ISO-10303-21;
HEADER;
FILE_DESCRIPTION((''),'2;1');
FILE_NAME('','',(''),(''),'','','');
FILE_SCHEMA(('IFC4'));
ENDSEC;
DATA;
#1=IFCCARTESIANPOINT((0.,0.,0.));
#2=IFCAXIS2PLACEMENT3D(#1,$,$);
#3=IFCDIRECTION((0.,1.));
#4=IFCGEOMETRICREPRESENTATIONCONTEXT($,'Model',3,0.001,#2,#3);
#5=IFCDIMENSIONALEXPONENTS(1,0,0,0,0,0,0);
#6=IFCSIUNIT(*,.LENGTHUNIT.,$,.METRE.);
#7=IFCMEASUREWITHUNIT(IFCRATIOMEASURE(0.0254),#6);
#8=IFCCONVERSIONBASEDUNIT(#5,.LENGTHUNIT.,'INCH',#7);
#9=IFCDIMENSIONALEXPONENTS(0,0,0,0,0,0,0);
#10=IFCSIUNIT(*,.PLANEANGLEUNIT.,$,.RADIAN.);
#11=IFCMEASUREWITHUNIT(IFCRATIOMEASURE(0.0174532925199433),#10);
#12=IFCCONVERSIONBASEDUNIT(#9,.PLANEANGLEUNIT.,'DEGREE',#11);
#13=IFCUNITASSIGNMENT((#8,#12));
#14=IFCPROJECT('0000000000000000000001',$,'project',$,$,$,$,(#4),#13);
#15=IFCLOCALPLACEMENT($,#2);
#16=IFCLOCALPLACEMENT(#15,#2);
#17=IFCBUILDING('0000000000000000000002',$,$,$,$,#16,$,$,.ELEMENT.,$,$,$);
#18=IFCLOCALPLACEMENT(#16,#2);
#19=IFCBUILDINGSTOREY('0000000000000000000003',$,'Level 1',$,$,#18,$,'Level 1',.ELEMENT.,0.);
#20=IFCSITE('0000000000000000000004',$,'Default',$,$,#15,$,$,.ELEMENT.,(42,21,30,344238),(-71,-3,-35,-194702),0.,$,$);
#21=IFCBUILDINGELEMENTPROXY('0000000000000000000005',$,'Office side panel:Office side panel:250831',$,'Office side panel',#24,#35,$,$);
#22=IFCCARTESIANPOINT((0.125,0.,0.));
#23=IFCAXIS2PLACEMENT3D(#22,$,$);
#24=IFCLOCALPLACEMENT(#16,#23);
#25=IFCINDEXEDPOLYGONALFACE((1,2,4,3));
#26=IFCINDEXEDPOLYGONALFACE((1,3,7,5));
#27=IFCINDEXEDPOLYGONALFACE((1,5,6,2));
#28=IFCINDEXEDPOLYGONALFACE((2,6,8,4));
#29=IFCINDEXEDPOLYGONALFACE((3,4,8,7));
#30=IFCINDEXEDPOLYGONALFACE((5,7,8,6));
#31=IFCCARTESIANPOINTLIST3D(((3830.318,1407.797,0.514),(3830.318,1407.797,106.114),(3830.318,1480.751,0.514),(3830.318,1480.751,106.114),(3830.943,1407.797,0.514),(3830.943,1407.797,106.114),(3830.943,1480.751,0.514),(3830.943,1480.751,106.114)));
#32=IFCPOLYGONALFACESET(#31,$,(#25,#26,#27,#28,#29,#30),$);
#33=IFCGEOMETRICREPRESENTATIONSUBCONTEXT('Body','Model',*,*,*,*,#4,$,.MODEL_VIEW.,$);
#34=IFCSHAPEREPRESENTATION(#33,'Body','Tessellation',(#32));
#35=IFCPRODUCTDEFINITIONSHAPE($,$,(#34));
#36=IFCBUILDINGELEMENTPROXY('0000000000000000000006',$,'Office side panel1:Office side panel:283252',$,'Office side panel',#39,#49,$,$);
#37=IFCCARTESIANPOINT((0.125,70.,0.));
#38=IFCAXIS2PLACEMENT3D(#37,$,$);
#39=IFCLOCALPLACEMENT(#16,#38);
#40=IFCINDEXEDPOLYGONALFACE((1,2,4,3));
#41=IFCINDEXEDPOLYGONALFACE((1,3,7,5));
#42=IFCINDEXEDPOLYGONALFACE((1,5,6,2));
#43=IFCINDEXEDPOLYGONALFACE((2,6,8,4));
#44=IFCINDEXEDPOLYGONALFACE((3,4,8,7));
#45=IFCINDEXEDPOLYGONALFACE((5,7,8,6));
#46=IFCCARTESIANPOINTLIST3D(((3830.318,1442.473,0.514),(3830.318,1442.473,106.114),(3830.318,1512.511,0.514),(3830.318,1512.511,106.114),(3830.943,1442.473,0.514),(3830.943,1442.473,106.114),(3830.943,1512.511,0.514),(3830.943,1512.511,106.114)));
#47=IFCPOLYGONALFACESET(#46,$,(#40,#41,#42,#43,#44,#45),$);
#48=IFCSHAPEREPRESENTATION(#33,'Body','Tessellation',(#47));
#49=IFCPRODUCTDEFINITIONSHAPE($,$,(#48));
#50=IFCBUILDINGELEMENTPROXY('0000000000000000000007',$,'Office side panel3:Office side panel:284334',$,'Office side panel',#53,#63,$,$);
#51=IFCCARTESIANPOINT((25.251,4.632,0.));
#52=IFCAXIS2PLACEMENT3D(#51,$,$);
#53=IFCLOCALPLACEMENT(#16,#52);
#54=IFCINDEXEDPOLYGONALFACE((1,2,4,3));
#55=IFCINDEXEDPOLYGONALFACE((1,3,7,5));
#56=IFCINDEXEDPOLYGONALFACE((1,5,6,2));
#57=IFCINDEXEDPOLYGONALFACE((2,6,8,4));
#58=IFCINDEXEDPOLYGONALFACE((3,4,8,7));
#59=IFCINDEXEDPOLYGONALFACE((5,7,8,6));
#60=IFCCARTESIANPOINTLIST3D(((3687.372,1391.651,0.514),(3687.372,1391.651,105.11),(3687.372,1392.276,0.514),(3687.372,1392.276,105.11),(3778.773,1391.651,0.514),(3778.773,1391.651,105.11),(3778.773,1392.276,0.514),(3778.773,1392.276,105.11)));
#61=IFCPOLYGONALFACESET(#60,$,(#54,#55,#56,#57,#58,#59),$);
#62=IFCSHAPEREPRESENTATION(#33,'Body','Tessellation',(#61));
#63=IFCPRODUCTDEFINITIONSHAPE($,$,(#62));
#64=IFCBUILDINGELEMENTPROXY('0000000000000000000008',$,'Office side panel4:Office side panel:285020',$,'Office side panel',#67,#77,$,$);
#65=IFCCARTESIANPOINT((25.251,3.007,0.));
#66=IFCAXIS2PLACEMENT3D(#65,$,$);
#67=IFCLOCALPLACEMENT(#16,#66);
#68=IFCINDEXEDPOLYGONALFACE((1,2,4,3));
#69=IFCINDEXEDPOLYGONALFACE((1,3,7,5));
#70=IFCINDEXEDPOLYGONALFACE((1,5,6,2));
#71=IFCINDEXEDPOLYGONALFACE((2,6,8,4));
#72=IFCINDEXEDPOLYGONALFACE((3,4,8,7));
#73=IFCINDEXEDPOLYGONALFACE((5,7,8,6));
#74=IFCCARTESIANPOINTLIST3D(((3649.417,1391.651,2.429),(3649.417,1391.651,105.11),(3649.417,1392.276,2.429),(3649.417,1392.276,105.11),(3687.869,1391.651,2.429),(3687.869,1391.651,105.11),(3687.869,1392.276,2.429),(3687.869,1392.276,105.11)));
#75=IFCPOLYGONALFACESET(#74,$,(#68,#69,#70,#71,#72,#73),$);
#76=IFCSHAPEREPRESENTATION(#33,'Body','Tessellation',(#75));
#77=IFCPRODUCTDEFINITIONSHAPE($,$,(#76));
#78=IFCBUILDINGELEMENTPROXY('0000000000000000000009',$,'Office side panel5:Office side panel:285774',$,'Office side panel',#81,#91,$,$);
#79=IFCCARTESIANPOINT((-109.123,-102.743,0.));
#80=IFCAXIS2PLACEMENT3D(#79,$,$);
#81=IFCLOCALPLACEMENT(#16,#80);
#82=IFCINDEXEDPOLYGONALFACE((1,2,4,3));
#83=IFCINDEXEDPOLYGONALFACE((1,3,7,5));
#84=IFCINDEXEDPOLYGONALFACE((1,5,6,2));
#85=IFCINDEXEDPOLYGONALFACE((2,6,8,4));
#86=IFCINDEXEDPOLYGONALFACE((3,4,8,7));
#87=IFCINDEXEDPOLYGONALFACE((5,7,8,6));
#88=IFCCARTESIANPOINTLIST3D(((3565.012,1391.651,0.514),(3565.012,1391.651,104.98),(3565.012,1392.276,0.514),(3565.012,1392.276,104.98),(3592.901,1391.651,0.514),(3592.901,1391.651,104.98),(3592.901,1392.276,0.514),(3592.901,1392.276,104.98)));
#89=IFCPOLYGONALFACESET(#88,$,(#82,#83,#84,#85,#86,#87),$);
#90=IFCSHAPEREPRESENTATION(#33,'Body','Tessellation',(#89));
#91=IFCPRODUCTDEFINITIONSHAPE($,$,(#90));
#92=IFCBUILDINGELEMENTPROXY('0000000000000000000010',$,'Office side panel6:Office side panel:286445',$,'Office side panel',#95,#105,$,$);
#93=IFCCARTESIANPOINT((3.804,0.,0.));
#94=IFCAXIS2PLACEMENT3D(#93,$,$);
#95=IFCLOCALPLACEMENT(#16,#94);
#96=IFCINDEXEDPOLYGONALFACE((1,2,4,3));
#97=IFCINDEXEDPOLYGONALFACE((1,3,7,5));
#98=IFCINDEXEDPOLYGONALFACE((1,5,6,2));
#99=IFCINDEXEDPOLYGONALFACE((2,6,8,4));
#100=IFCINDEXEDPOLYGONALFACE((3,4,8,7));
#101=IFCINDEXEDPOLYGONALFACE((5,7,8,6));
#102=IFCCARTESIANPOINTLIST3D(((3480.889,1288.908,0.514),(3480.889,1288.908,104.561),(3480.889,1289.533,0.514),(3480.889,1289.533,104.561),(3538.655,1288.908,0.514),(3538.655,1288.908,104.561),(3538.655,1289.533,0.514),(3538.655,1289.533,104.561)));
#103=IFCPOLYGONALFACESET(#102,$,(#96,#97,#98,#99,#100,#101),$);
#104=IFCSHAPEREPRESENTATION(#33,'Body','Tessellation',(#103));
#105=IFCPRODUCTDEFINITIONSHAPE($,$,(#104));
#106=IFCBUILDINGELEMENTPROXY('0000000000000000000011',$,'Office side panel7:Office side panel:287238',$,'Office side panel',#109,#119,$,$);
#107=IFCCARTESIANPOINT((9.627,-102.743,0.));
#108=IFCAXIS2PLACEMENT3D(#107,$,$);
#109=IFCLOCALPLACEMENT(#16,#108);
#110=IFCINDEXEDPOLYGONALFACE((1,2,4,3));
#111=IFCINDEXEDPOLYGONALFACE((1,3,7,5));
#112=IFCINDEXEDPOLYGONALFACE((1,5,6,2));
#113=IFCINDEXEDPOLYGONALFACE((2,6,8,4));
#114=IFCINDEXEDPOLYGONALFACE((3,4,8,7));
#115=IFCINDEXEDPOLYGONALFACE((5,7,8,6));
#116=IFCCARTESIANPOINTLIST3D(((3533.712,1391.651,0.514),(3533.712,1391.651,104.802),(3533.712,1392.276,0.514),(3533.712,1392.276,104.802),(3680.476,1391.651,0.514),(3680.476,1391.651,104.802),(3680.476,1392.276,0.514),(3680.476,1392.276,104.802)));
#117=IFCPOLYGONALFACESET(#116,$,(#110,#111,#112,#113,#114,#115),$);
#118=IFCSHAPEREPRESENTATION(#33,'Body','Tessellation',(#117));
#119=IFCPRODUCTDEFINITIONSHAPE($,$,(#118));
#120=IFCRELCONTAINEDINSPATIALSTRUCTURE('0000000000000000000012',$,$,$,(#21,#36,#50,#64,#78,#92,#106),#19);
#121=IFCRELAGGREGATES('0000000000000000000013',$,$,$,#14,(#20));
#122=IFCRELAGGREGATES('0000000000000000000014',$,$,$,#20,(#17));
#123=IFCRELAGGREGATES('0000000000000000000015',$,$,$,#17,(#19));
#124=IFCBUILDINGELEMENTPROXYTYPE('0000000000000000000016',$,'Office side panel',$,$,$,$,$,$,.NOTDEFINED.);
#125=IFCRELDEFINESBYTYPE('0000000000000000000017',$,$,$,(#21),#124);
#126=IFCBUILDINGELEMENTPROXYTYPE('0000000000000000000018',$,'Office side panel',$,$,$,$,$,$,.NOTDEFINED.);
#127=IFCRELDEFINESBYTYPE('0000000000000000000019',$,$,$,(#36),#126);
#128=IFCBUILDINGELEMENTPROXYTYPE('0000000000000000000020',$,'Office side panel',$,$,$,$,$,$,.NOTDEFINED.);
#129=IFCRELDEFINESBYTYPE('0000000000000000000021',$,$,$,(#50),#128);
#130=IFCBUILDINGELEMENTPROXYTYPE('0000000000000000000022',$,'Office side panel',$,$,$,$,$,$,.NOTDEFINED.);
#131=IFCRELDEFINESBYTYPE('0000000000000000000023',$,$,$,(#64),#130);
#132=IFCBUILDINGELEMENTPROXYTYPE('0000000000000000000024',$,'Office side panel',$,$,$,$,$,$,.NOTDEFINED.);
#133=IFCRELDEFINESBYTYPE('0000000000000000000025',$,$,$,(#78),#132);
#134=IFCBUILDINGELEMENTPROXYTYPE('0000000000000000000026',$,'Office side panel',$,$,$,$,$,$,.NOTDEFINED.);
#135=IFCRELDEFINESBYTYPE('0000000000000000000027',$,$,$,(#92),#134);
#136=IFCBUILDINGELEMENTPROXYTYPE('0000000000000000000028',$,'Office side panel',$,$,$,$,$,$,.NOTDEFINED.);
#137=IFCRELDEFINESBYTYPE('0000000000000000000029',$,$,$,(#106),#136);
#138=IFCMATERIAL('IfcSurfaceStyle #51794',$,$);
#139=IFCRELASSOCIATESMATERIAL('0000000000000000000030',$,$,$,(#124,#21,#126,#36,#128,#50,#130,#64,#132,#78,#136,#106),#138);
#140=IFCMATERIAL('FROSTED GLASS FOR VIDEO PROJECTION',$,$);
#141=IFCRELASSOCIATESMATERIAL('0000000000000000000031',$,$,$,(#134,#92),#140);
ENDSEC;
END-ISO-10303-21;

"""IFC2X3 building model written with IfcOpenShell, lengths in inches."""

from ifc_helpers import new_model, entity, si_unit, converted_unit, direction, frame, frame_2d, origin, origin_2d_with_axis, place, context, subcontext, project, spatial, rectangle, extrude, source, transform, mapped, material, type_object, type_shapes, element, save


model = new_model("IFC2X3")

# Units and contexts
model_context = context("Model", 3, precision=0.001, world=origin(), true_north=direction((0.0, 1.0)))
body_context = subcontext(model_context, "Body", "Model", "MODEL_VIEW")
ifc_project = project(units=[converted_unit("LENGTHUNIT", "INCH", entity("IfcRatioMeasure", 0.0254), si_unit("LENGTHUNIT", "METRE"), dimensions=[1, 0, 0, 0, 0, 0, 0]), converted_unit("PLANEANGLEUNIT", "DEGREE", entity("IfcRatioMeasure", 0.0174532925199433), si_unit("PLANEANGLEUNIT", "RADIAN"), dimensions=[0, 0, 0, 0, 0, 0, 0])], contexts=[model_context])

# Site, building, storey
site_placement = place(None, origin())
site = spatial("IfcSite", under=ifc_project, at=site_placement, Name="Default", CompositionType="ELEMENT", RefLatitude=(42, 21, 30, 344238), RefLongitude=(-71, -3, -35, -194702), RefElevation=0.0)
building_placement = place(site_placement, origin())
building = spatial("IfcBuilding", under=site, at=building_placement, CompositionType="ELEMENT")
storey_placement = place(building_placement, origin())
storey = spatial("IfcBuildingStorey", under=building, at=storey_placement, Name="Level 1", LongName="Level 1", CompositionType="ELEMENT", Elevation=0.0)

# Building element proxies
ifc_material_1 = material(Name="IfcSurfaceStyle #51794")
building_element_proxy_type_1 = type_object("IfcBuildingElementProxyType", Name="Office side panel", PredefinedType="NOTDEFINED", material=ifc_material_1)
shared_shape_1 = source(origin(), body_context, "Body", "SweptSolid", [
    extrude(rectangle(XDim=0.625, YDim=72.954, at=frame_2d((0.0, 0.0), x_axis=(1.0, 0.0))), frame((3830.631, 1444.274, 0.514)), (0.0, 0.0, 1.0), 105.6),
])
type_shapes(building_element_proxy_type_1, [shared_shape_1])
proxy_1_placement = place(building_placement, frame((0.125, 0.0, 0.0)))
element("IfcBuildingElementProxy", 1, at=proxy_1_placement, inside=storey, type_object=building_element_proxy_type_1, material=ifc_material_1, Name="Office side panel:Office side panel:250831", ObjectType="Office side panel", context=body_context, shape_type="MappedRepresentation", body=[
    mapped(shared_shape_1, transform((0.0, 0.0, 0.0), scale=1.0)),
])
building_element_proxy_type_2 = type_object("IfcBuildingElementProxyType", Name="Office side panel", PredefinedType="NOTDEFINED", material=ifc_material_1)
shared_shape_2 = source(origin(), body_context, "Body", "SweptSolid", [
    extrude(rectangle(XDim=0.625, YDim=70.038, at=frame_2d((0.0, 0.0), x_axis=(1.0, 0.0))), frame((3830.631, 1477.492, 0.514)), (0.0, 0.0, 1.0), 105.6),
])
type_shapes(building_element_proxy_type_2, [shared_shape_2])
proxy_2_placement = place(building_placement, frame((0.125, 70.0, 0.0)))
element("IfcBuildingElementProxy", 2, at=proxy_2_placement, inside=storey, type_object=building_element_proxy_type_2, material=ifc_material_1, Name="Office side panel1:Office side panel:283252", ObjectType="Office side panel", context=body_context, shape_type="MappedRepresentation", body=[
    mapped(shared_shape_2, transform((0.0, 0.0, 0.0), scale=1.0)),
])
building_element_proxy_type_3 = type_object("IfcBuildingElementProxyType", Name="Office side panel", PredefinedType="NOTDEFINED", material=ifc_material_1)
shared_shape_3 = source(origin(), body_context, "Body", "SweptSolid", [
    extrude(rectangle(XDim=91.401, YDim=0.625, at=frame_2d((0.0, 0.0), x_axis=(1.0, 0.0))), frame((3733.073, 1391.963, 0.514), z_axis=(0.0, 0.0, 1.0), x_axis=(-1.0, 0.0, 0.0)), (0.0, 0.0, 1.0), 104.597),
])
type_shapes(building_element_proxy_type_3, [shared_shape_3])
proxy_3_placement = place(building_placement, frame((25.251, 4.632, 0.0)))
element("IfcBuildingElementProxy", 3, at=proxy_3_placement, inside=storey, type_object=building_element_proxy_type_3, material=ifc_material_1, Name="Office side panel3:Office side panel:284334", ObjectType="Office side panel", context=body_context, shape_type="MappedRepresentation", body=[
    mapped(shared_shape_3, transform((0.0, 0.0, 0.0), scale=1.0)),
])
building_element_proxy_type_4 = type_object("IfcBuildingElementProxyType", Name="Office side panel", PredefinedType="NOTDEFINED", material=ifc_material_1)
shared_shape_4 = source(origin(), body_context, "Body", "SweptSolid", [
    extrude(rectangle(XDim=38.453, YDim=0.625, at=frame_2d((0.0, 0.0), x_axis=(1.0, 0.0))), frame((3668.643, 1391.963, 2.429), z_axis=(0.0, 0.0, 1.0), x_axis=(-1.0, 0.0, 0.0)), (0.0, 0.0, 1.0), 102.681),
])
type_shapes(building_element_proxy_type_4, [shared_shape_4])
proxy_4_placement = place(building_placement, frame((25.251, 3.007, 0.0)))
element("IfcBuildingElementProxy", 4, at=proxy_4_placement, inside=storey, type_object=building_element_proxy_type_4, material=ifc_material_1, Name="Office side panel4:Office side panel:285020", ObjectType="Office side panel", context=body_context, shape_type="MappedRepresentation", body=[
    mapped(shared_shape_4, transform((0.0, 0.0, 0.0), scale=1.0)),
])
building_element_proxy_type_5 = type_object("IfcBuildingElementProxyType", Name="Office side panel", PredefinedType="NOTDEFINED", material=ifc_material_1)
shared_shape_5 = source(origin(), body_context, "Body", "SweptSolid", [
    extrude(rectangle(XDim=27.889, YDim=0.625, at=frame_2d((0.0, 0.0), x_axis=(1.0, 0.0))), frame((3578.957, 1391.963, 0.514), z_axis=(0.0, 0.0, 1.0), x_axis=(-1.0, 0.0, 0.0)), (0.0, 0.0, 1.0), 104.466),
])
type_shapes(building_element_proxy_type_5, [shared_shape_5])
proxy_5_placement = place(building_placement, frame((-109.123, -102.743, 0.0)))
element("IfcBuildingElementProxy", 5, at=proxy_5_placement, inside=storey, type_object=building_element_proxy_type_5, material=ifc_material_1, Name="Office side panel5:Office side panel:285774", ObjectType="Office side panel", context=body_context, shape_type="MappedRepresentation", body=[
    mapped(shared_shape_5, transform((0.0, 0.0, 0.0), scale=1.0)),
])
ifc_material_2 = material(Name="FROSTED GLASS FOR VIDEO PROJECTION")
building_element_proxy_type_6 = type_object("IfcBuildingElementProxyType", Name="Office side panel", PredefinedType="NOTDEFINED", material=ifc_material_2)
shared_shape_6 = source(origin(), body_context, "Body", "SweptSolid", [
    extrude(rectangle(XDim=57.766, YDim=0.625, at=origin_2d_with_axis()), frame((3509.772, 1289.22, 0.514), z_axis=(0.0, 0.0, 1.0), x_axis=(-1.0, 0.0, 0.0)), (0.0, 0.0, 1.0), 104.047),
])
type_shapes(building_element_proxy_type_6, [shared_shape_6])
proxy_6_placement = place(building_placement, frame((3.804, 0.0, 0.0)))
element("IfcBuildingElementProxy", 6, at=proxy_6_placement, inside=storey, type_object=building_element_proxy_type_6, material=ifc_material_2, Name="Office side panel6:Office side panel:286445", ObjectType="Office side panel", context=body_context, shape_type="MappedRepresentation", body=[
    mapped(shared_shape_6, transform((0.0, 0.0, 0.0), scale=1.0)),
])
building_element_proxy_type_7 = type_object("IfcBuildingElementProxyType", Name="Office side panel", PredefinedType="NOTDEFINED", material=ifc_material_1)
shared_shape_7 = source(origin(), body_context, "Body", "SweptSolid", [
    extrude(rectangle(XDim=146.764, YDim=0.625, at=frame_2d((0.0, 0.0), x_axis=(1.0, 0.0))), frame((3607.094, 1391.963, 0.514), z_axis=(0.0, 0.0, 1.0), x_axis=(-1.0, 0.0, 0.0)), (0.0, 0.0, 1.0), 104.288),
])
type_shapes(building_element_proxy_type_7, [shared_shape_7])
proxy_7_placement = place(building_placement, frame((9.627, -102.743, 0.0)))
element("IfcBuildingElementProxy", 7, at=proxy_7_placement, inside=storey, type_object=building_element_proxy_type_7, material=ifc_material_1, Name="Office side panel7:Office side panel:287238", ObjectType="Office side panel", context=body_context, shape_type="MappedRepresentation", body=[
    mapped(shared_shape_7, transform((0.0, 0.0, 0.0), scale=1.0)),
])

save(model, "model.ifc")
